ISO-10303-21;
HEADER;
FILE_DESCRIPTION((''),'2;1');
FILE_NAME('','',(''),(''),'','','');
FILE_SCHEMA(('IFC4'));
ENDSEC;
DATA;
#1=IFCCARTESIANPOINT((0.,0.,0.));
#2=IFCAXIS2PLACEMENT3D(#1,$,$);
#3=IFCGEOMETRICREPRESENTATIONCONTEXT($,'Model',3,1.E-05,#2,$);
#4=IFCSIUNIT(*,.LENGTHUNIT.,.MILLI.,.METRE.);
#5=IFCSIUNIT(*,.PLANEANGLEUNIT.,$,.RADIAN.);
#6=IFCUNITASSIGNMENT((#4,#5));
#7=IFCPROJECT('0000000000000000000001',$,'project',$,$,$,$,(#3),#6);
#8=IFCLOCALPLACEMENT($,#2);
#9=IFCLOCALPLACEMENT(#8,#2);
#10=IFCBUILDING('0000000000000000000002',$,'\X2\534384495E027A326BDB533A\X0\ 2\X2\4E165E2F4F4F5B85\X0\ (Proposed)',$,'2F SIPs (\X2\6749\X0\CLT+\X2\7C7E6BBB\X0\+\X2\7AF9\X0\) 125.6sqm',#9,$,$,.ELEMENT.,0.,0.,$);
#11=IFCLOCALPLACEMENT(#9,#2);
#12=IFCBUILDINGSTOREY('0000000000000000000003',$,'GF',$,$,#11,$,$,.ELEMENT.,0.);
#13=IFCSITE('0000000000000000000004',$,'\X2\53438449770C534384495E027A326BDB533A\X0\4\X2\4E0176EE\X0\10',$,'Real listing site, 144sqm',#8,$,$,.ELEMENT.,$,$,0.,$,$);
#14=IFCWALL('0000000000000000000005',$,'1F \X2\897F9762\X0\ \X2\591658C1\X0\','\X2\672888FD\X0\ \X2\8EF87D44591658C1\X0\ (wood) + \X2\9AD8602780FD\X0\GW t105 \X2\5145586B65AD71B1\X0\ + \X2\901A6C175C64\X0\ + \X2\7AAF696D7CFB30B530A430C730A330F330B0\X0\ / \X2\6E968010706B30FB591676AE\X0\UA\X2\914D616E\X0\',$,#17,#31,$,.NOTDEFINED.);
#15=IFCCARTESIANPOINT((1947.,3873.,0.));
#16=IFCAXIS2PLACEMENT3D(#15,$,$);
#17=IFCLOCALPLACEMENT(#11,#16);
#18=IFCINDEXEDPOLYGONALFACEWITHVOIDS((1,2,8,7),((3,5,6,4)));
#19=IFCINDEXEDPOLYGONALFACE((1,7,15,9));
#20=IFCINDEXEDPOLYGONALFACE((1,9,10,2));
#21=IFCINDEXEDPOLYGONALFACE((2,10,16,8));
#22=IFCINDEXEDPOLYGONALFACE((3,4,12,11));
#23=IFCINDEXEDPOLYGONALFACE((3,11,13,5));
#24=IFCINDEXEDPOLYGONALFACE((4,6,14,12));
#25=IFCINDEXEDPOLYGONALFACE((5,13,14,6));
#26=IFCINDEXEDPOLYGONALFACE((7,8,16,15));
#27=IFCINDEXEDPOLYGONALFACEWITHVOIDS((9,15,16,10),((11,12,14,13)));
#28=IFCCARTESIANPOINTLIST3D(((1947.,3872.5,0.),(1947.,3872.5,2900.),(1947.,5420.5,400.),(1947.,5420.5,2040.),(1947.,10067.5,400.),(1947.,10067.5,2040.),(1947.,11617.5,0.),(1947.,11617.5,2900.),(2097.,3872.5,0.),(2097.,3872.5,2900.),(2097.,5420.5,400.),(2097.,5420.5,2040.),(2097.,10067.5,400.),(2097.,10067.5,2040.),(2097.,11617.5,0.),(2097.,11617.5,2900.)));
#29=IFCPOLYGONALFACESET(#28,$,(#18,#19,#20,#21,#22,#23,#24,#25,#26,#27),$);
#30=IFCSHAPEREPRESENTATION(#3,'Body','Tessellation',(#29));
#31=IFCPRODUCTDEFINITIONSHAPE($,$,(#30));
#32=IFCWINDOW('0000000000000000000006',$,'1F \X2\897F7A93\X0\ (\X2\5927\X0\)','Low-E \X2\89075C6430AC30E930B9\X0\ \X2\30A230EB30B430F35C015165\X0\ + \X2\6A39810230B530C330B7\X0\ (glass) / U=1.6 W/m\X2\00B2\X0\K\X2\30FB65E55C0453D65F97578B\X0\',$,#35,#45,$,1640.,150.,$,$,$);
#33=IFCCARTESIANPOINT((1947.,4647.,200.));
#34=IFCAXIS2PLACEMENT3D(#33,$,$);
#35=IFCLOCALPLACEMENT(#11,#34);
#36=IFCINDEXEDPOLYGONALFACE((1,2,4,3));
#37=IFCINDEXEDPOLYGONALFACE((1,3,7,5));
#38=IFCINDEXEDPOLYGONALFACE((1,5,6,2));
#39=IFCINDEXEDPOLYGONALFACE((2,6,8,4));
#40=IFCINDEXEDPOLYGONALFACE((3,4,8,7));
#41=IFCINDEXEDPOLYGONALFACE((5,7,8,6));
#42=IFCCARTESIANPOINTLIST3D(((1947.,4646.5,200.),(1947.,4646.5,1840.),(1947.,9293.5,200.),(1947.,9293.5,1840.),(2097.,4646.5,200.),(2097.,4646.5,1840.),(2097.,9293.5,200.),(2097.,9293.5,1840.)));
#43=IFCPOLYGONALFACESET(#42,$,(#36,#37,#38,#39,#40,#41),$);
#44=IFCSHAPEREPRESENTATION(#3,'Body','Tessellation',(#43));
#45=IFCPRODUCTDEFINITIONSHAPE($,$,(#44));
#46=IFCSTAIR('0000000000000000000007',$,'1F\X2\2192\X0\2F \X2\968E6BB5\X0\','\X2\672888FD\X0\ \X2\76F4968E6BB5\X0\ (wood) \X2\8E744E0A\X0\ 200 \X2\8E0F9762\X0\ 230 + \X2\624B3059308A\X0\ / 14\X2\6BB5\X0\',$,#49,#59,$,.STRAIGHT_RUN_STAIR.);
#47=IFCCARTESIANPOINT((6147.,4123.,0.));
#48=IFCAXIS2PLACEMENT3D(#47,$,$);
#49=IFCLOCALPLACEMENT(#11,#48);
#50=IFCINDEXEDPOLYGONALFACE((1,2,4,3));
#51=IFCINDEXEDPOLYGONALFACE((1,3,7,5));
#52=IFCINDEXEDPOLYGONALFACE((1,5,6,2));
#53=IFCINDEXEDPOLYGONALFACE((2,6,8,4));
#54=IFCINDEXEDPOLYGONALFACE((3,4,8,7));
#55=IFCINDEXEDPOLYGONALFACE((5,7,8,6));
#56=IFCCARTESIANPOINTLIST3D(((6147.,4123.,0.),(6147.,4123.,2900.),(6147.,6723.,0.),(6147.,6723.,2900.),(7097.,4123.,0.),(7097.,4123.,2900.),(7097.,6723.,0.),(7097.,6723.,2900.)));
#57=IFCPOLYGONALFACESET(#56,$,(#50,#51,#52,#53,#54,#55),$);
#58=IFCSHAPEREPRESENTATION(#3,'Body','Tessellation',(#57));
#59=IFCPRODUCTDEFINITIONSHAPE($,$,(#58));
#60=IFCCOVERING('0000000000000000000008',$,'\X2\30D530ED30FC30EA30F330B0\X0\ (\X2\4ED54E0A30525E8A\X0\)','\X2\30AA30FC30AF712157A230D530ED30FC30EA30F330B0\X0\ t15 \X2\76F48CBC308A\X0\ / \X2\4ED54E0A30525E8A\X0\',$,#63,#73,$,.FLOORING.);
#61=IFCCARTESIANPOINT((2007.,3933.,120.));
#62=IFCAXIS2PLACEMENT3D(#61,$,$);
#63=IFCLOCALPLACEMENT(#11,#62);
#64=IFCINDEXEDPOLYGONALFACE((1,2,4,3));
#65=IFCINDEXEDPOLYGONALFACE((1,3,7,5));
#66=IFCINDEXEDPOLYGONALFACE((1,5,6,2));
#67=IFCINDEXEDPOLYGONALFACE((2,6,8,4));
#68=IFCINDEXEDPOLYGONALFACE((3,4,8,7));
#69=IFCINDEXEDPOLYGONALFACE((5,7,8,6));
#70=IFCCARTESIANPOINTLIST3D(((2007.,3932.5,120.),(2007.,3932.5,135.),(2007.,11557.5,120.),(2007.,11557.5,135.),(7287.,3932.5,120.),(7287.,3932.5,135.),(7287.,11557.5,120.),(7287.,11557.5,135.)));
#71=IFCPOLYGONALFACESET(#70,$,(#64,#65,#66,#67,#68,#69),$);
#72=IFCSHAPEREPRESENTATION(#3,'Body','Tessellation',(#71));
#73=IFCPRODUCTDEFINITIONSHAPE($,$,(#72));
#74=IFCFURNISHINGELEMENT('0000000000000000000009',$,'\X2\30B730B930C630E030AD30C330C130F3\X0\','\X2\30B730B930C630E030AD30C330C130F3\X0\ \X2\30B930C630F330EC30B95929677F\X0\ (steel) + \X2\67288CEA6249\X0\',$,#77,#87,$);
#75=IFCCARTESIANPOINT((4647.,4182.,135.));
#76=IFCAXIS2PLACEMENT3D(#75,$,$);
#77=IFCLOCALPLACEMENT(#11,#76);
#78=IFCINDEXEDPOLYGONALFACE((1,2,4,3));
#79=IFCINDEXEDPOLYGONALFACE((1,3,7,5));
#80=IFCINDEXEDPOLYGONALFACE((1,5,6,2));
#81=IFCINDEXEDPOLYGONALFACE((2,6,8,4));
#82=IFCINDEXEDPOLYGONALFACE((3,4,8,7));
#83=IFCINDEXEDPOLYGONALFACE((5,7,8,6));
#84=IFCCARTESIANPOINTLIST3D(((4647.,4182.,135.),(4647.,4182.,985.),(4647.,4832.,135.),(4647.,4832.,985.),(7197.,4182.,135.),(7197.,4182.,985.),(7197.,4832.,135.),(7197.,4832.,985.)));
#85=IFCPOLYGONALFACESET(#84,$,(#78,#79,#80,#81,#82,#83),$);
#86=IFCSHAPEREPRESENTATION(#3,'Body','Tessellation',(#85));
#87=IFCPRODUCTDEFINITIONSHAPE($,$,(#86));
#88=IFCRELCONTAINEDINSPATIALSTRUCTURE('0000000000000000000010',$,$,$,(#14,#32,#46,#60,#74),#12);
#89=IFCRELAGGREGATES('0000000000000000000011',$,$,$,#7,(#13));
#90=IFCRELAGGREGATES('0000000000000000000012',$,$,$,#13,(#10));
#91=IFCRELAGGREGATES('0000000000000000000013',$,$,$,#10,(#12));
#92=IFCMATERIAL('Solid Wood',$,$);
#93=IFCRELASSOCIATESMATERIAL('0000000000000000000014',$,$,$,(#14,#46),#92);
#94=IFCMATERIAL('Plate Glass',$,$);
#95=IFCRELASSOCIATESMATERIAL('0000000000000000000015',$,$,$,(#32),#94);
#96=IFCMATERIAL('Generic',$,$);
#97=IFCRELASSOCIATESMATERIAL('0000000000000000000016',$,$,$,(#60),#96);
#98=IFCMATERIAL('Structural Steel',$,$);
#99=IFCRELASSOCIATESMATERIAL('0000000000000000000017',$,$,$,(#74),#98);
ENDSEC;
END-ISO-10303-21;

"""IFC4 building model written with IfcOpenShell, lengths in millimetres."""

from ifc_helpers import new_model, si_unit, frame, frame_2d, origin, place, context, project, spatial, rectangle, extrude, material, element, fill, save


model = new_model("IFC4")

# Units and contexts
model_context = context("Model", 3, precision=1e-05, world=origin())
ifc_project = project(units=[si_unit("LENGTHUNIT", "METRE", prefix="MILLI"), si_unit("PLANEANGLEUNIT", "RADIAN")], contexts=[model_context])

# Site, building, storey
site_placement = place(None, origin())
site = spatial("IfcSite", under=ifc_project, at=site_placement, Name="千葉県千葉市稲毛区4丁目10", ObjectType="Real listing site, 144sqm", CompositionType="ELEMENT", RefElevation=0.0)
building_placement = place(site_placement, origin())
building = spatial("IfcBuilding", under=site, at=building_placement, Name="千葉市稲毛区 2世帯住宅 (Proposed)", ObjectType="2F SIPs (杉CLT+籾殻+竹) 125.6sqm", CompositionType="ELEMENT", ElevationOfRefHeight=0.0, ElevationOfTerrain=0.0)
storey_placement = place(building_placement, origin())
storey = spatial("IfcBuildingStorey", under=building, at=storey_placement, Name="GF", CompositionType="ELEMENT", Elevation=0.0)

# Shared definitions
ifc_material_1 = material(Name="Solid Wood")

# Shared definitions
ifc_material_2 = material(Name="Plate Glass")
ifc_material_3 = material(Name="Generic")

# Wall, opening, window
wall_1_placement = place(storey_placement, frame((1947.0, 3873.0, 0.0)))
wall_1 = element("IfcWall", 1, at=wall_1_placement, inside=storey, material=ifc_material_1, Name="1F 西面 外壁", Description="木製 軸組外壁 (wood) + 高性能GW t105 充填断熱 + 通気層 + 窯業系サイディング / 準耐火・外皮UA配慮", PredefinedType="NOTDEFINED", context=model_context, shape_type="SweptSolid", body=[
    extrude(rectangle(XDim=150.0, YDim=7745.0, at=frame_2d((75.0, 3872.0))), frame((1947.0, 3873.0, 0.0)), (0.0, 0.0, 1.0), 2900.0),
])
opening_1_placement = place(storey_placement, frame((1947.0, 4647.0, 200.0)))
opening_1 = element("IfcOpeningElement", 2, at=opening_1_placement, cuts=wall_1, PredefinedType="NOTDEFINED", context=model_context, shape_type="SweptSolid", body=[
    extrude(rectangle(XDim=150.0, YDim=4647.0, at=frame_2d((75.0, 2323.0))), frame((1947.0, 4647.0, 200.0)), (0.0, 0.0, 1.0), 1640.0),
])
window_1_placement = place(storey_placement, frame((1947.0, 4647.0, 200.0)))
window_1 = element("IfcWindow", 3, at=window_1_placement, inside=storey, material=ifc_material_2, Name="1F 西窓 (大)", Description="Low-E 複層ガラス アルゴン封入 + 樹脂サッシ (glass) / U=1.6 W/m²K・日射取得型", OverallHeight=1640.0, OverallWidth=150.0, context=model_context, shape_type="SweptSolid", body=[
    extrude(rectangle(XDim=150.0, YDim=4647.0, at=frame_2d((75.0, 2323.0))), frame((1947.0, 4647.0, 200.0)), (0.0, 0.0, 1.0), 1640.0),
])
fill(opening_1, window_1)

# Stair
stair_placement = place(storey_placement, frame((6147.0, 4123.0, 0.0)))
element("IfcStair", 4, at=stair_placement, inside=storey, material=ifc_material_1, Name="1F→2F 階段", Description="木製 直階段 (wood) 蹴上 200 踏面 230 + 手すり / 14段", PredefinedType="STRAIGHT_RUN_STAIR", context=model_context, shape_type="SweptSolid", body=[
    extrude(rectangle(XDim=950.0, YDim=2600.0, at=frame_2d((475.0, 1300.0))), frame((6147.0, 4123.0, 0.0)), (0.0, 0.0, 1.0), 2900.0),
])

# Covering
covering_placement = place(storey_placement, frame((2007.0, 3933.0, 120.0)))
element("IfcCovering", 5, at=covering_placement, inside=storey, material=ifc_material_3, Name="フローリング (仕上げ床)", Description="オーク無垢フローリング t15 直貼り / 仕上げ床", PredefinedType="FLOORING", context=model_context, shape_type="SweptSolid", body=[
    extrude(rectangle(XDim=5280.0, YDim=7625.0, at=frame_2d((2640.0, 3812.0))), frame((2007.0, 3933.0, 120.0)), (0.0, 0.0, 1.0), 15.0),
])

# Furnishing element
ifc_material_4 = material(Name="Structural Steel")
furnishing_placement = place(storey_placement, frame((4647.0, 4182.0, 135.0)))
element("IfcFurnishingElement", 6, at=furnishing_placement, inside=storey, material=ifc_material_4, Name="システムキッチン", Description="システムキッチン ステンレス天板 (steel) + 木質扉", context=model_context, shape_type="SweptSolid", body=[
    extrude(rectangle(XDim=2550.0, YDim=650.0, at=frame_2d((1275.0, 325.0))), frame((4647.0, 4182.0, 135.0)), (0.0, 0.0, 1.0), 850.0),
])

save(model, "model.ifc")
